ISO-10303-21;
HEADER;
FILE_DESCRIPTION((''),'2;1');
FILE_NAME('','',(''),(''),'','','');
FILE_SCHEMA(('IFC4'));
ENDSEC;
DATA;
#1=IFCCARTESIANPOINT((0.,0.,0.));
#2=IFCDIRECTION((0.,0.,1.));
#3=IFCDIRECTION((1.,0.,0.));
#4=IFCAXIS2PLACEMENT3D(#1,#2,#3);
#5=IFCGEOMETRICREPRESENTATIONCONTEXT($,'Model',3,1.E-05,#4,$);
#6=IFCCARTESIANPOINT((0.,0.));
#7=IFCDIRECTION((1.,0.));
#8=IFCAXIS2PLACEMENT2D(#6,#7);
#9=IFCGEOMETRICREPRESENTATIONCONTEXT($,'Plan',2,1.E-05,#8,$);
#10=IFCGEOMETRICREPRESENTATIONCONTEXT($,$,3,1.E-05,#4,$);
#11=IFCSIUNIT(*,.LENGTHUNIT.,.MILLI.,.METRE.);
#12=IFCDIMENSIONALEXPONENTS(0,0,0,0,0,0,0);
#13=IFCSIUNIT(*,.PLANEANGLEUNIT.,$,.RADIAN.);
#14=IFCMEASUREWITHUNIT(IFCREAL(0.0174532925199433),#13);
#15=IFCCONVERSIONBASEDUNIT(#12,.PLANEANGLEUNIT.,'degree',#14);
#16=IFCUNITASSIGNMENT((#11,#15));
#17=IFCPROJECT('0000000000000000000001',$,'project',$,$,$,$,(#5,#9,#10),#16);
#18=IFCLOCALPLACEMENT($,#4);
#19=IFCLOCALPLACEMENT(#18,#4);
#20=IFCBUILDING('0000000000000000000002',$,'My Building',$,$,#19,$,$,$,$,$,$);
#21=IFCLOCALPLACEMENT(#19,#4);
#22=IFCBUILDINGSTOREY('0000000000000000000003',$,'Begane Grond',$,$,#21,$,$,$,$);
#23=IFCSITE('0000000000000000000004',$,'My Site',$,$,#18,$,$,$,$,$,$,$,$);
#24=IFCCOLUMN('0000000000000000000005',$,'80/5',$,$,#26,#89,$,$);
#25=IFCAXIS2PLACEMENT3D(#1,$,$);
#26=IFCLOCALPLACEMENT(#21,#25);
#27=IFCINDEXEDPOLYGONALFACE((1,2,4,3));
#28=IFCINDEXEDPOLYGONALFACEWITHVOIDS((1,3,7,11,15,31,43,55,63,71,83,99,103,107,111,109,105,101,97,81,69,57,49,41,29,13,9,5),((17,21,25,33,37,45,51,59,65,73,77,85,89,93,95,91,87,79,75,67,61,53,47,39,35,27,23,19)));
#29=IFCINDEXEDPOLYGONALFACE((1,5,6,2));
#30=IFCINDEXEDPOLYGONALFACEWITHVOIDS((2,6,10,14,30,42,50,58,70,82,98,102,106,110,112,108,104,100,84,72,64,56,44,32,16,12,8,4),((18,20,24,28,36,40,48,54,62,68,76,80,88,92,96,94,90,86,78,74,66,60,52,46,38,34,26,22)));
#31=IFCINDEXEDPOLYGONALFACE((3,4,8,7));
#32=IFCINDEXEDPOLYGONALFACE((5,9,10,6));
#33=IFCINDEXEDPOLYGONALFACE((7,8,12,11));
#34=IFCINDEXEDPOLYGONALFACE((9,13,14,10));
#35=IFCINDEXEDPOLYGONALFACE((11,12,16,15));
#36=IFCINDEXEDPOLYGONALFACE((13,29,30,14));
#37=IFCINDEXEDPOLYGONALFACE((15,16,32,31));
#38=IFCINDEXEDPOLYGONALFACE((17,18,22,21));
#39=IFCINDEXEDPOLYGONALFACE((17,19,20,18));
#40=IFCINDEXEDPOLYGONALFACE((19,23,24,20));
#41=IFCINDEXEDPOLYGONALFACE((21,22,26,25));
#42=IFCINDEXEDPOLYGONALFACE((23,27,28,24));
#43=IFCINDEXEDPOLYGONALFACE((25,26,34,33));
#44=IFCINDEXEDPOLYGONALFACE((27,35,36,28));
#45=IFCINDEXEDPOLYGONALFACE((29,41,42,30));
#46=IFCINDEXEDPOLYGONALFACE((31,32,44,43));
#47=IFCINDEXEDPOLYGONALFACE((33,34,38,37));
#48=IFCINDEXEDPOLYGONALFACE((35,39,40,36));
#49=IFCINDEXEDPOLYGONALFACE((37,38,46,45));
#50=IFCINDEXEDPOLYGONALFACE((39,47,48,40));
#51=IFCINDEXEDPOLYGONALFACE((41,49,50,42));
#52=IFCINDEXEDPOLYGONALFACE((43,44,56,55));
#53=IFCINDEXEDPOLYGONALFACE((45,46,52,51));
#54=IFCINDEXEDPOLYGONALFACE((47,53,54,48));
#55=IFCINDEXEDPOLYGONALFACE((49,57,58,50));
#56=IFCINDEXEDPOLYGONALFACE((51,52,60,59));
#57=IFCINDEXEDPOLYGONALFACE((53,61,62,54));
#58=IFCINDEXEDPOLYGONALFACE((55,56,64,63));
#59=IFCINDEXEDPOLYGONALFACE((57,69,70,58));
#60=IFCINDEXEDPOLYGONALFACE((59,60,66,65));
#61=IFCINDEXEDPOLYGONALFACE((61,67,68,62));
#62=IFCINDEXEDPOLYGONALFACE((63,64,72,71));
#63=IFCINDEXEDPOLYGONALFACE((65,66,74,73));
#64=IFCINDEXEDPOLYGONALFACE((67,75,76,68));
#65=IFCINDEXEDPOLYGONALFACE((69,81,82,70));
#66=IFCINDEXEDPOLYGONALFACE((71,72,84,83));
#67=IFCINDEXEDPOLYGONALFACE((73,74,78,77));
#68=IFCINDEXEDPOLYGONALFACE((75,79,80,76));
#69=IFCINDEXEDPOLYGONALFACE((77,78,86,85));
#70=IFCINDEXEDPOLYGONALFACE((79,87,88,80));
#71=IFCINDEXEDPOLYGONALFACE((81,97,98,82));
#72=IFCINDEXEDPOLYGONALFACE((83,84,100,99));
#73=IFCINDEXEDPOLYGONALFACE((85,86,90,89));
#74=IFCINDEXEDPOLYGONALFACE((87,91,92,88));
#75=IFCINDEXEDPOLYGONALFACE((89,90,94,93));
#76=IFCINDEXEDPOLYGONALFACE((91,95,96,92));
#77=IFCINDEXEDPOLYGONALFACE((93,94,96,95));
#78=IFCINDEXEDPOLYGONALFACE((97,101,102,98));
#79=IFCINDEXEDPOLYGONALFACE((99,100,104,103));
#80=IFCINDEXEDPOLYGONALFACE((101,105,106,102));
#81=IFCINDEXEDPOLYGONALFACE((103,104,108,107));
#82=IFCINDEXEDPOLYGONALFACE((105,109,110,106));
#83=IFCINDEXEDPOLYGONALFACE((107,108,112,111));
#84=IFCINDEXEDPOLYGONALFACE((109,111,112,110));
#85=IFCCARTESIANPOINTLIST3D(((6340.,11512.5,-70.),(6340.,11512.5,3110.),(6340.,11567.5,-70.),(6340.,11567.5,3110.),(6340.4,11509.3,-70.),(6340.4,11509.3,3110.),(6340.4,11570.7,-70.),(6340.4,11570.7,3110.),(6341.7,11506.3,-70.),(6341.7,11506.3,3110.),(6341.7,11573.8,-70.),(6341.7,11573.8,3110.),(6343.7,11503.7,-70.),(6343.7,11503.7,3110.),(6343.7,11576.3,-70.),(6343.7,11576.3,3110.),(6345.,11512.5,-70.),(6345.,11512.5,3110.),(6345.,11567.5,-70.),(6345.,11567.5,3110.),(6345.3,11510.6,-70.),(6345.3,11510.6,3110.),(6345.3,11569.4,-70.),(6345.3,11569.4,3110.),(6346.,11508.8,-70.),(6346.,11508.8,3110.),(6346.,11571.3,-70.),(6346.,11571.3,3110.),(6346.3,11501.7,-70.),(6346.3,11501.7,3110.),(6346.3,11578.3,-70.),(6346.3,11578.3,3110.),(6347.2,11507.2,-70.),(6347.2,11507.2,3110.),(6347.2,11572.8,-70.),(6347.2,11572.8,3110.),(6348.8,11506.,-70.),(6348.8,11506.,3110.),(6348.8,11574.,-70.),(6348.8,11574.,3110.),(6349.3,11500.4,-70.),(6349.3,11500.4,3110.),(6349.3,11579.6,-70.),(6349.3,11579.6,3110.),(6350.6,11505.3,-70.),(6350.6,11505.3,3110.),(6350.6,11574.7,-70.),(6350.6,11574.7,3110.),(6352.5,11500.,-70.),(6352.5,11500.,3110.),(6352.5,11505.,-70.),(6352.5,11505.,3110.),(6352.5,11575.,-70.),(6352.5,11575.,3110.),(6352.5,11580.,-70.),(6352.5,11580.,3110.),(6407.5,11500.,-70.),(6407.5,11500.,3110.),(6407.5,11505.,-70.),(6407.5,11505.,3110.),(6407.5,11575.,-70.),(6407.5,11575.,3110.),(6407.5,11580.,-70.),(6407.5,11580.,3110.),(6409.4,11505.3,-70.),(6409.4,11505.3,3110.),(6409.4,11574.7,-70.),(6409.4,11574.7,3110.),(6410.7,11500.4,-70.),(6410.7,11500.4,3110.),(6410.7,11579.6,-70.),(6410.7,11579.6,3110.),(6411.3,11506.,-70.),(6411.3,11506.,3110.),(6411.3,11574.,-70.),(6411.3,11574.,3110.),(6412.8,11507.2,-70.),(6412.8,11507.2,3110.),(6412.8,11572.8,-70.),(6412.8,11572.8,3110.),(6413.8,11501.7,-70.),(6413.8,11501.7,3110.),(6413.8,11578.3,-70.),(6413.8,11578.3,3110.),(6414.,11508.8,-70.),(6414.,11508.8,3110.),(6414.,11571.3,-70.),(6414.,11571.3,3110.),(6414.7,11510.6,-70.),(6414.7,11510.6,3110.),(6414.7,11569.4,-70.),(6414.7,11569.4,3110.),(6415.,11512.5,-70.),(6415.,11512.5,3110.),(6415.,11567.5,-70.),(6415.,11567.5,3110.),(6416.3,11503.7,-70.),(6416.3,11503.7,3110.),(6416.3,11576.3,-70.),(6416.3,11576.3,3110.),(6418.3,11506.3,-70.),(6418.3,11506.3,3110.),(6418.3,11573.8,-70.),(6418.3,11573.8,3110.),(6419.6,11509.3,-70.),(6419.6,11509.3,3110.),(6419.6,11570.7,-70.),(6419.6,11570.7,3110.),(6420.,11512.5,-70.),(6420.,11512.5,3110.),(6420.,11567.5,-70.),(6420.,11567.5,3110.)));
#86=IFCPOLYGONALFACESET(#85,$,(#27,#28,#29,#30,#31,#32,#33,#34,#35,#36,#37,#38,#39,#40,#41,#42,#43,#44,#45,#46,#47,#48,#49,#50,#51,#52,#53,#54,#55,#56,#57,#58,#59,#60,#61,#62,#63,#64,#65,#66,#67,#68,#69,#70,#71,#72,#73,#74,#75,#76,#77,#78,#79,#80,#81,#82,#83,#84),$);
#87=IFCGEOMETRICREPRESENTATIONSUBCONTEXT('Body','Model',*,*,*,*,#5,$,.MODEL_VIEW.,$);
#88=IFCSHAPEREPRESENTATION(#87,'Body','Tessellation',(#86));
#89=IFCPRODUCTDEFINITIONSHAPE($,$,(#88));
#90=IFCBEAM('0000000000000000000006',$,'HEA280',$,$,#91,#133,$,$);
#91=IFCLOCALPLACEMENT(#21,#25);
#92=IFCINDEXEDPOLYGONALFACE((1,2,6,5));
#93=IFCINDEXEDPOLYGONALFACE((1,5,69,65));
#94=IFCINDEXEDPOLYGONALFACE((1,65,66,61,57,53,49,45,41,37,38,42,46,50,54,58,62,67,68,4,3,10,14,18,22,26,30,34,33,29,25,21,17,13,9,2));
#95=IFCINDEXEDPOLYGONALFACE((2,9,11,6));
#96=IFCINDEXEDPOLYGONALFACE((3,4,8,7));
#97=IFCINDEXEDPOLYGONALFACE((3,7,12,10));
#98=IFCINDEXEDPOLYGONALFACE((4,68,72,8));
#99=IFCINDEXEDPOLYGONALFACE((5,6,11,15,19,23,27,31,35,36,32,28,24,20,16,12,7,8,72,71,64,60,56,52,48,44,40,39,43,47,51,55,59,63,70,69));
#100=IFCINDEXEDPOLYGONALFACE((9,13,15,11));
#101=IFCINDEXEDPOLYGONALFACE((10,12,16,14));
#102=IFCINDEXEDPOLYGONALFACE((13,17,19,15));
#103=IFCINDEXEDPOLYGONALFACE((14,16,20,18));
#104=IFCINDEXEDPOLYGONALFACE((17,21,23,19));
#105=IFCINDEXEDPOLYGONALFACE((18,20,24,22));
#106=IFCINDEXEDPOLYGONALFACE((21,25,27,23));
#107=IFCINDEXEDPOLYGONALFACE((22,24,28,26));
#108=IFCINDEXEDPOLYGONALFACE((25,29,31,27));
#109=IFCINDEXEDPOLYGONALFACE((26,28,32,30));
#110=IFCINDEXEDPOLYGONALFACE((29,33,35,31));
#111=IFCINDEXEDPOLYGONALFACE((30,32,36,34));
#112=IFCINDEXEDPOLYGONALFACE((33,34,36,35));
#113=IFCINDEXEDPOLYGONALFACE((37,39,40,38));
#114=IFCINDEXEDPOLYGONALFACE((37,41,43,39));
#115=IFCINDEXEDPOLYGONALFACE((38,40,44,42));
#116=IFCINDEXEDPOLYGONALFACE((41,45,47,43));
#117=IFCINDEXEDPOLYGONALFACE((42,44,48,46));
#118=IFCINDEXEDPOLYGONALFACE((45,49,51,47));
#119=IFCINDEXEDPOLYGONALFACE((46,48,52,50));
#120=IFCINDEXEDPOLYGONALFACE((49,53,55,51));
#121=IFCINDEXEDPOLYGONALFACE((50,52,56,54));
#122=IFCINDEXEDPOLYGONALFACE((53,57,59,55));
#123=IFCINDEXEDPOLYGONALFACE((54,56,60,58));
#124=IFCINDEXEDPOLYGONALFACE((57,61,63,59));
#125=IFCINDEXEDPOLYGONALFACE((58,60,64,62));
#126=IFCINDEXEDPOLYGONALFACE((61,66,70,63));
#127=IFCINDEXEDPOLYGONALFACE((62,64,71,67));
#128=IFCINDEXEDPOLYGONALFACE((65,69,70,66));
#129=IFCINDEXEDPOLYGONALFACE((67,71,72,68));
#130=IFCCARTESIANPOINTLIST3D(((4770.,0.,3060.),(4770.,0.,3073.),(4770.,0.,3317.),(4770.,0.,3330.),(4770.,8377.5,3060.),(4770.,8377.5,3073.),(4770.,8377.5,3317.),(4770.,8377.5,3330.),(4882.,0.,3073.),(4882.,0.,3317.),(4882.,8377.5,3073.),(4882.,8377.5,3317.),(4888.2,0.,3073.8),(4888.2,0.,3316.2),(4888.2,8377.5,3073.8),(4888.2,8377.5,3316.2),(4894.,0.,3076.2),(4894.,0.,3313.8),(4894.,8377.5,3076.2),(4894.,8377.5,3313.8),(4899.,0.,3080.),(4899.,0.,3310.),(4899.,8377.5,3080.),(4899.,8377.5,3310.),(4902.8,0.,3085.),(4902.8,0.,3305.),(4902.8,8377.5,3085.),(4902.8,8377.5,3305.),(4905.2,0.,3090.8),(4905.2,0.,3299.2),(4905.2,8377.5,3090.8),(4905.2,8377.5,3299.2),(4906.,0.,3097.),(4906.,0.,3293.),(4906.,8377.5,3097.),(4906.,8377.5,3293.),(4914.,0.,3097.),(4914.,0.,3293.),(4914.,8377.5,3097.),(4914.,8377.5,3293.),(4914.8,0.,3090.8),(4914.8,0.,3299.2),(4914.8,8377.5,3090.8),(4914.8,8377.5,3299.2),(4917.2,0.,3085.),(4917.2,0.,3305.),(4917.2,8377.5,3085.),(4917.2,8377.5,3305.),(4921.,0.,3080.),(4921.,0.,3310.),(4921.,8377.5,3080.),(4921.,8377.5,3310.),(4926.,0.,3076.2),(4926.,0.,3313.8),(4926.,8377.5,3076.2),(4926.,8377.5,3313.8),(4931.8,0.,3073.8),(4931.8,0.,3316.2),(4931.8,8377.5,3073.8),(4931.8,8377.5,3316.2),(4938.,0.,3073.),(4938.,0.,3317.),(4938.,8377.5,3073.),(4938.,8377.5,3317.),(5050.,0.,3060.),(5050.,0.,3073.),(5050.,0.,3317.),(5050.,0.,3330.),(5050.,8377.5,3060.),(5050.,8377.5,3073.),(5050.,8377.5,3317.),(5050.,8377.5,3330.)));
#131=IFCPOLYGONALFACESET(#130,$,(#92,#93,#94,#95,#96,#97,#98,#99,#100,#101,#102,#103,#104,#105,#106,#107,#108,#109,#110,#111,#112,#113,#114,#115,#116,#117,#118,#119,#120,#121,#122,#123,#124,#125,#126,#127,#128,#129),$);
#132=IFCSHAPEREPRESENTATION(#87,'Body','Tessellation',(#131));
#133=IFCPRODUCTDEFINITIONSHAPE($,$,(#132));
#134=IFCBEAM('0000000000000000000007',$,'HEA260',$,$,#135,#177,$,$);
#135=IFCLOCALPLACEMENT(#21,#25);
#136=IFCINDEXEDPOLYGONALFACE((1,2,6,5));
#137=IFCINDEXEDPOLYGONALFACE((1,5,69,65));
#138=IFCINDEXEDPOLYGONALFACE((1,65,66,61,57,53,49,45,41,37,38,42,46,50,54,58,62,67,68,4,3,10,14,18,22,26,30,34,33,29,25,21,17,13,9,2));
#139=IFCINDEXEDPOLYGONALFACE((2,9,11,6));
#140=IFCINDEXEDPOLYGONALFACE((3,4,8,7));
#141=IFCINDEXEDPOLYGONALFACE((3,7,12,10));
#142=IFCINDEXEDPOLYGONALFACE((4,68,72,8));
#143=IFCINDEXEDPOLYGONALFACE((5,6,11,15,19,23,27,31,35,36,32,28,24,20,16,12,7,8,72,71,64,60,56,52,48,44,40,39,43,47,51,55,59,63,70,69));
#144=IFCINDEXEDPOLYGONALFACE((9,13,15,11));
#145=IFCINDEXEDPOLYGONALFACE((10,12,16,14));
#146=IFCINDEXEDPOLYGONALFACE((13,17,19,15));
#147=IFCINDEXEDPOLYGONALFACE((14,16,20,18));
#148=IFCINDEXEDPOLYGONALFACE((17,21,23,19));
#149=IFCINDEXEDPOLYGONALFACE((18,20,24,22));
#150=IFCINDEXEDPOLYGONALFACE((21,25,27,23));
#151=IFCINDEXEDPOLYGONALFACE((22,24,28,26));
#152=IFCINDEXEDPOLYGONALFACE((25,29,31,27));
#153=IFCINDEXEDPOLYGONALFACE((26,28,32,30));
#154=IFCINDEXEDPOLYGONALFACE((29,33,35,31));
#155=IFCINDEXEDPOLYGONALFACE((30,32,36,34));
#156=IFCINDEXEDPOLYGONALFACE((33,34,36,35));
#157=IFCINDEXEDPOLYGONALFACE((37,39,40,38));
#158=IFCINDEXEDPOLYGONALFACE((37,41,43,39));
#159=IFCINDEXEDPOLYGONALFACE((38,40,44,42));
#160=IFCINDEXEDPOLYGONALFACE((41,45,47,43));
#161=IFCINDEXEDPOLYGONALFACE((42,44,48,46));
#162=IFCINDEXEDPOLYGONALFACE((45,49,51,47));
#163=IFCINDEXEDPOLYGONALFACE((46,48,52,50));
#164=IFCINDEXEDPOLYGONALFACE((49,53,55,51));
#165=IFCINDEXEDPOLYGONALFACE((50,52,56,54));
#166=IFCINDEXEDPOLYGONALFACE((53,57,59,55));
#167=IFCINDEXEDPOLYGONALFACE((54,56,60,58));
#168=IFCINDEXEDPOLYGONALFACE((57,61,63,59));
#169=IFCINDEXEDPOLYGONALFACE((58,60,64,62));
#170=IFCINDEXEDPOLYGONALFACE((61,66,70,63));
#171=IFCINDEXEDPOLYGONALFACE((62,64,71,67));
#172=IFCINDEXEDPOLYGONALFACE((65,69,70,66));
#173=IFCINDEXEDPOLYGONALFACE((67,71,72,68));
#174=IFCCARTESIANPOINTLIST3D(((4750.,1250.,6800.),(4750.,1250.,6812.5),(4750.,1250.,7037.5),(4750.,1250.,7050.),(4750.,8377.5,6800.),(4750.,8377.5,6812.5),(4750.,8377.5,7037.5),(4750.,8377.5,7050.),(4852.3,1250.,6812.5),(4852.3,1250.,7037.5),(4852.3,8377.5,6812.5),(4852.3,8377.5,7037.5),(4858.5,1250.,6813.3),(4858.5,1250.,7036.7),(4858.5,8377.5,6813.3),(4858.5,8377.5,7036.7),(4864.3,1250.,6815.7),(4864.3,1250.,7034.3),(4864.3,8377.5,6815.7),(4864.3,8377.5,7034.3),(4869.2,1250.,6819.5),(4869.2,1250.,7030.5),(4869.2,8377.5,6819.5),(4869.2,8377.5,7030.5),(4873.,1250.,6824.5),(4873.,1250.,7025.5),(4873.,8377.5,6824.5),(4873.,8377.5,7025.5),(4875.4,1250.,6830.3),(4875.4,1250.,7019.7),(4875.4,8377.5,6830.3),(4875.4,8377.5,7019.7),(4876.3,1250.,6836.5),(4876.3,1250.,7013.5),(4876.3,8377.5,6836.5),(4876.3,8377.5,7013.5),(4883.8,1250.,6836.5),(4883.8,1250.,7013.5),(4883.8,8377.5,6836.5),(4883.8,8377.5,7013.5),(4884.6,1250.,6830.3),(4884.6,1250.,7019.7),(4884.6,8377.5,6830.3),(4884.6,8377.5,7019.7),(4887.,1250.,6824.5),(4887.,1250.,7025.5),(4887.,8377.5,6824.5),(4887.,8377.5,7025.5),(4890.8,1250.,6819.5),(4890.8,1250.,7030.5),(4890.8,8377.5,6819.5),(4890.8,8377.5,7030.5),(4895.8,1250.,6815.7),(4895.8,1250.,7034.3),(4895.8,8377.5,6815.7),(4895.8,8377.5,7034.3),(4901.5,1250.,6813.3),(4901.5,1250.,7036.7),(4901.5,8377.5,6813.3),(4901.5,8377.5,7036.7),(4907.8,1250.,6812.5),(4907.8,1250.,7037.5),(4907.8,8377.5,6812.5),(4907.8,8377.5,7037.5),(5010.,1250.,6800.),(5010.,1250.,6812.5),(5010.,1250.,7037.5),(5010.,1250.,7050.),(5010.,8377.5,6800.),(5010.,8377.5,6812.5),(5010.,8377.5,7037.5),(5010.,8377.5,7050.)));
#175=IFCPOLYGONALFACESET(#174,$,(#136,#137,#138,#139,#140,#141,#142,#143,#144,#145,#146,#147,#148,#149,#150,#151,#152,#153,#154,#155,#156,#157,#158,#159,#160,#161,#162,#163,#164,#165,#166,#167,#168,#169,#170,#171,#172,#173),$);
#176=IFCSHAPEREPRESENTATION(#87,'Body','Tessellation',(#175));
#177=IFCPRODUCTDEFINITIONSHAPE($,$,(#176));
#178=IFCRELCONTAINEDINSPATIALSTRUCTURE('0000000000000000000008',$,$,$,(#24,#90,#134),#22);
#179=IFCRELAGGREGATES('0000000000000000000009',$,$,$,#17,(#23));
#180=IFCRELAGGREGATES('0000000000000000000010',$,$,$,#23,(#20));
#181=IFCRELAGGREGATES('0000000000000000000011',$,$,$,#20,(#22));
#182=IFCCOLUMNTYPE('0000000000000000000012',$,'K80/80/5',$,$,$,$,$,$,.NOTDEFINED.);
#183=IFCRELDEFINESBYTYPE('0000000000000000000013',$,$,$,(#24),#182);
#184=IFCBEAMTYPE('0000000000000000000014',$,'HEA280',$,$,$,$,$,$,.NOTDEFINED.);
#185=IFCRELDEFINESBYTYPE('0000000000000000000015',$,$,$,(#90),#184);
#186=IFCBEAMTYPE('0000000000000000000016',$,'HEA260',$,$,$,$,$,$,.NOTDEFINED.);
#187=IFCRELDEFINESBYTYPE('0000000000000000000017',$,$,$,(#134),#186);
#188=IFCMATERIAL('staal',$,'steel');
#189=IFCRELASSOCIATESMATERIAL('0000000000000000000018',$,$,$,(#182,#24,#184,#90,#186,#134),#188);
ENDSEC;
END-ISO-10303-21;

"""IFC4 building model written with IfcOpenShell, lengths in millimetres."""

from ifc_helpers import new_model, entity, si_unit, converted_unit, frame, origin_with_axes, origin_2d_with_axis, place, context, subcontext, project, spatial, hollow_rectangle, i_section, extrude, material, material_profile, profile_set, profile_usage, type_object, element, save


model = new_model("IFC4")

# Units and contexts
model_context = context("Model", 3, precision=1e-05, world=origin_with_axes())
plan_context = context("Plan", 2, precision=1e-05, world=origin_2d_with_axis())
context_of_model = context(None, 3, precision=1e-05, world=origin_with_axes())
body_context = subcontext(model_context, "Body", "Model", "MODEL_VIEW")
ifc_project = project(units=[si_unit("LENGTHUNIT", "METRE", prefix="MILLI"), converted_unit("PLANEANGLEUNIT", "degree", entity("IfcReal", 0.0174532925199433), si_unit("PLANEANGLEUNIT", "RADIAN"), dimensions=[0, 0, 0, 0, 0, 0, 0])], contexts=[model_context, plan_context, context_of_model])

# Site, building, storey
site_placement = place(None, origin_with_axes())
site = spatial("IfcSite", under=ifc_project, at=site_placement, Name="My Site")
building_placement = place(site_placement, origin_with_axes())
building = spatial("IfcBuilding", under=site, at=building_placement, Name="My Building")
storey_placement = place(building_placement, origin_with_axes())
storey = spatial("IfcBuildingStorey", under=building, at=storey_placement, Name="Begane Grond")

# Column
ifc_material = material(Name="staal", Category="steel")
ifc_material_profile_1 = material_profile(ifc_material, hollow_rectangle(XDim=80.0, YDim=80.0, WallThickness=5.0, InnerFilletRadius=7.5, OuterFilletRadius=12.5))
ifc_profile_set_1 = profile_set([ifc_material_profile_1], Name="K80/80/5")
ifc_profile_usage_1 = profile_usage(ifc_profile_set_1)
column_type_1 = type_object("IfcColumnType", Name="K80/80/5", PredefinedType="NOTDEFINED", material=ifc_profile_set_1)
column_1_placement = place(storey_placement, frame((6380.0, 11540.0, -70.0), z_axis=(0.0, 0.0, 1.0), x_axis=(1.0, 0.0, 0.0)))
element("IfcColumn", 1, at=column_1_placement, inside=storey, type_object=column_type_1, material=ifc_profile_usage_1, Name="80/5", context=body_context, shape_type="SweptSolid", body=[
    extrude(hollow_rectangle(XDim=80.0, YDim=80.0, WallThickness=5.0, InnerFilletRadius=7.5, OuterFilletRadius=12.5), origin_with_axes(), (0.0, 0.0, 1.0), 3180.0),
])

# Beams
ifc_material_profile_2 = material_profile(ifc_material, i_section(OverallWidth=280.0, OverallDepth=270.0, WebThickness=8.0, FlangeThickness=13.0, FilletRadius=24.0))
ifc_profile_set_2 = profile_set([ifc_material_profile_2], Name="HEA280")
ifc_profile_usage_2 = profile_usage(ifc_profile_set_2)
beam_type_1 = type_object("IfcBeamType", Name="HEA280", PredefinedType="NOTDEFINED", material=ifc_profile_set_2)
beam_1_placement = place(storey_placement, frame((4910.0, 0.0, 3195.0), z_axis=(0.0, 1.0, 0.0), x_axis=(-1.0, 0.0, 0.0)))
element("IfcBeam", 2, at=beam_1_placement, inside=storey, type_object=beam_type_1, material=ifc_profile_usage_2, Name="HEA280", context=body_context, shape_type="SweptSolid", body=[
    extrude(i_section(OverallWidth=280.0, OverallDepth=270.0, WebThickness=8.0, FlangeThickness=13.0, FilletRadius=24.0), origin_with_axes(), (0.0, 0.0, 1.0), 8377.5),
])
ifc_material_profile_3 = material_profile(ifc_material, i_section(OverallWidth=260.0, OverallDepth=250.0, WebThickness=7.5, FlangeThickness=12.5, FilletRadius=24.0))
ifc_profile_set_3 = profile_set([ifc_material_profile_3], Name="HEA260")
ifc_profile_usage_3 = profile_usage(ifc_profile_set_3)
beam_type_2 = type_object("IfcBeamType", Name="HEA260", PredefinedType="NOTDEFINED", material=ifc_profile_set_3)
beam_2_placement = place(storey_placement, frame((4880.0, 1250.0, 6925.0), z_axis=(0.0, 1.0, 0.0), x_axis=(-1.0, 0.0, 0.0)))
element("IfcBeam", 3, at=beam_2_placement, inside=storey, type_object=beam_type_2, material=ifc_profile_usage_3, Name="HEA260", context=body_context, shape_type="SweptSolid", body=[
    extrude(i_section(OverallWidth=260.0, OverallDepth=250.0, WebThickness=7.5, FlangeThickness=12.5, FilletRadius=24.0), origin_with_axes(), (0.0, 0.0, 1.0), 7127.5),
])

save(model, "model.ifc")
